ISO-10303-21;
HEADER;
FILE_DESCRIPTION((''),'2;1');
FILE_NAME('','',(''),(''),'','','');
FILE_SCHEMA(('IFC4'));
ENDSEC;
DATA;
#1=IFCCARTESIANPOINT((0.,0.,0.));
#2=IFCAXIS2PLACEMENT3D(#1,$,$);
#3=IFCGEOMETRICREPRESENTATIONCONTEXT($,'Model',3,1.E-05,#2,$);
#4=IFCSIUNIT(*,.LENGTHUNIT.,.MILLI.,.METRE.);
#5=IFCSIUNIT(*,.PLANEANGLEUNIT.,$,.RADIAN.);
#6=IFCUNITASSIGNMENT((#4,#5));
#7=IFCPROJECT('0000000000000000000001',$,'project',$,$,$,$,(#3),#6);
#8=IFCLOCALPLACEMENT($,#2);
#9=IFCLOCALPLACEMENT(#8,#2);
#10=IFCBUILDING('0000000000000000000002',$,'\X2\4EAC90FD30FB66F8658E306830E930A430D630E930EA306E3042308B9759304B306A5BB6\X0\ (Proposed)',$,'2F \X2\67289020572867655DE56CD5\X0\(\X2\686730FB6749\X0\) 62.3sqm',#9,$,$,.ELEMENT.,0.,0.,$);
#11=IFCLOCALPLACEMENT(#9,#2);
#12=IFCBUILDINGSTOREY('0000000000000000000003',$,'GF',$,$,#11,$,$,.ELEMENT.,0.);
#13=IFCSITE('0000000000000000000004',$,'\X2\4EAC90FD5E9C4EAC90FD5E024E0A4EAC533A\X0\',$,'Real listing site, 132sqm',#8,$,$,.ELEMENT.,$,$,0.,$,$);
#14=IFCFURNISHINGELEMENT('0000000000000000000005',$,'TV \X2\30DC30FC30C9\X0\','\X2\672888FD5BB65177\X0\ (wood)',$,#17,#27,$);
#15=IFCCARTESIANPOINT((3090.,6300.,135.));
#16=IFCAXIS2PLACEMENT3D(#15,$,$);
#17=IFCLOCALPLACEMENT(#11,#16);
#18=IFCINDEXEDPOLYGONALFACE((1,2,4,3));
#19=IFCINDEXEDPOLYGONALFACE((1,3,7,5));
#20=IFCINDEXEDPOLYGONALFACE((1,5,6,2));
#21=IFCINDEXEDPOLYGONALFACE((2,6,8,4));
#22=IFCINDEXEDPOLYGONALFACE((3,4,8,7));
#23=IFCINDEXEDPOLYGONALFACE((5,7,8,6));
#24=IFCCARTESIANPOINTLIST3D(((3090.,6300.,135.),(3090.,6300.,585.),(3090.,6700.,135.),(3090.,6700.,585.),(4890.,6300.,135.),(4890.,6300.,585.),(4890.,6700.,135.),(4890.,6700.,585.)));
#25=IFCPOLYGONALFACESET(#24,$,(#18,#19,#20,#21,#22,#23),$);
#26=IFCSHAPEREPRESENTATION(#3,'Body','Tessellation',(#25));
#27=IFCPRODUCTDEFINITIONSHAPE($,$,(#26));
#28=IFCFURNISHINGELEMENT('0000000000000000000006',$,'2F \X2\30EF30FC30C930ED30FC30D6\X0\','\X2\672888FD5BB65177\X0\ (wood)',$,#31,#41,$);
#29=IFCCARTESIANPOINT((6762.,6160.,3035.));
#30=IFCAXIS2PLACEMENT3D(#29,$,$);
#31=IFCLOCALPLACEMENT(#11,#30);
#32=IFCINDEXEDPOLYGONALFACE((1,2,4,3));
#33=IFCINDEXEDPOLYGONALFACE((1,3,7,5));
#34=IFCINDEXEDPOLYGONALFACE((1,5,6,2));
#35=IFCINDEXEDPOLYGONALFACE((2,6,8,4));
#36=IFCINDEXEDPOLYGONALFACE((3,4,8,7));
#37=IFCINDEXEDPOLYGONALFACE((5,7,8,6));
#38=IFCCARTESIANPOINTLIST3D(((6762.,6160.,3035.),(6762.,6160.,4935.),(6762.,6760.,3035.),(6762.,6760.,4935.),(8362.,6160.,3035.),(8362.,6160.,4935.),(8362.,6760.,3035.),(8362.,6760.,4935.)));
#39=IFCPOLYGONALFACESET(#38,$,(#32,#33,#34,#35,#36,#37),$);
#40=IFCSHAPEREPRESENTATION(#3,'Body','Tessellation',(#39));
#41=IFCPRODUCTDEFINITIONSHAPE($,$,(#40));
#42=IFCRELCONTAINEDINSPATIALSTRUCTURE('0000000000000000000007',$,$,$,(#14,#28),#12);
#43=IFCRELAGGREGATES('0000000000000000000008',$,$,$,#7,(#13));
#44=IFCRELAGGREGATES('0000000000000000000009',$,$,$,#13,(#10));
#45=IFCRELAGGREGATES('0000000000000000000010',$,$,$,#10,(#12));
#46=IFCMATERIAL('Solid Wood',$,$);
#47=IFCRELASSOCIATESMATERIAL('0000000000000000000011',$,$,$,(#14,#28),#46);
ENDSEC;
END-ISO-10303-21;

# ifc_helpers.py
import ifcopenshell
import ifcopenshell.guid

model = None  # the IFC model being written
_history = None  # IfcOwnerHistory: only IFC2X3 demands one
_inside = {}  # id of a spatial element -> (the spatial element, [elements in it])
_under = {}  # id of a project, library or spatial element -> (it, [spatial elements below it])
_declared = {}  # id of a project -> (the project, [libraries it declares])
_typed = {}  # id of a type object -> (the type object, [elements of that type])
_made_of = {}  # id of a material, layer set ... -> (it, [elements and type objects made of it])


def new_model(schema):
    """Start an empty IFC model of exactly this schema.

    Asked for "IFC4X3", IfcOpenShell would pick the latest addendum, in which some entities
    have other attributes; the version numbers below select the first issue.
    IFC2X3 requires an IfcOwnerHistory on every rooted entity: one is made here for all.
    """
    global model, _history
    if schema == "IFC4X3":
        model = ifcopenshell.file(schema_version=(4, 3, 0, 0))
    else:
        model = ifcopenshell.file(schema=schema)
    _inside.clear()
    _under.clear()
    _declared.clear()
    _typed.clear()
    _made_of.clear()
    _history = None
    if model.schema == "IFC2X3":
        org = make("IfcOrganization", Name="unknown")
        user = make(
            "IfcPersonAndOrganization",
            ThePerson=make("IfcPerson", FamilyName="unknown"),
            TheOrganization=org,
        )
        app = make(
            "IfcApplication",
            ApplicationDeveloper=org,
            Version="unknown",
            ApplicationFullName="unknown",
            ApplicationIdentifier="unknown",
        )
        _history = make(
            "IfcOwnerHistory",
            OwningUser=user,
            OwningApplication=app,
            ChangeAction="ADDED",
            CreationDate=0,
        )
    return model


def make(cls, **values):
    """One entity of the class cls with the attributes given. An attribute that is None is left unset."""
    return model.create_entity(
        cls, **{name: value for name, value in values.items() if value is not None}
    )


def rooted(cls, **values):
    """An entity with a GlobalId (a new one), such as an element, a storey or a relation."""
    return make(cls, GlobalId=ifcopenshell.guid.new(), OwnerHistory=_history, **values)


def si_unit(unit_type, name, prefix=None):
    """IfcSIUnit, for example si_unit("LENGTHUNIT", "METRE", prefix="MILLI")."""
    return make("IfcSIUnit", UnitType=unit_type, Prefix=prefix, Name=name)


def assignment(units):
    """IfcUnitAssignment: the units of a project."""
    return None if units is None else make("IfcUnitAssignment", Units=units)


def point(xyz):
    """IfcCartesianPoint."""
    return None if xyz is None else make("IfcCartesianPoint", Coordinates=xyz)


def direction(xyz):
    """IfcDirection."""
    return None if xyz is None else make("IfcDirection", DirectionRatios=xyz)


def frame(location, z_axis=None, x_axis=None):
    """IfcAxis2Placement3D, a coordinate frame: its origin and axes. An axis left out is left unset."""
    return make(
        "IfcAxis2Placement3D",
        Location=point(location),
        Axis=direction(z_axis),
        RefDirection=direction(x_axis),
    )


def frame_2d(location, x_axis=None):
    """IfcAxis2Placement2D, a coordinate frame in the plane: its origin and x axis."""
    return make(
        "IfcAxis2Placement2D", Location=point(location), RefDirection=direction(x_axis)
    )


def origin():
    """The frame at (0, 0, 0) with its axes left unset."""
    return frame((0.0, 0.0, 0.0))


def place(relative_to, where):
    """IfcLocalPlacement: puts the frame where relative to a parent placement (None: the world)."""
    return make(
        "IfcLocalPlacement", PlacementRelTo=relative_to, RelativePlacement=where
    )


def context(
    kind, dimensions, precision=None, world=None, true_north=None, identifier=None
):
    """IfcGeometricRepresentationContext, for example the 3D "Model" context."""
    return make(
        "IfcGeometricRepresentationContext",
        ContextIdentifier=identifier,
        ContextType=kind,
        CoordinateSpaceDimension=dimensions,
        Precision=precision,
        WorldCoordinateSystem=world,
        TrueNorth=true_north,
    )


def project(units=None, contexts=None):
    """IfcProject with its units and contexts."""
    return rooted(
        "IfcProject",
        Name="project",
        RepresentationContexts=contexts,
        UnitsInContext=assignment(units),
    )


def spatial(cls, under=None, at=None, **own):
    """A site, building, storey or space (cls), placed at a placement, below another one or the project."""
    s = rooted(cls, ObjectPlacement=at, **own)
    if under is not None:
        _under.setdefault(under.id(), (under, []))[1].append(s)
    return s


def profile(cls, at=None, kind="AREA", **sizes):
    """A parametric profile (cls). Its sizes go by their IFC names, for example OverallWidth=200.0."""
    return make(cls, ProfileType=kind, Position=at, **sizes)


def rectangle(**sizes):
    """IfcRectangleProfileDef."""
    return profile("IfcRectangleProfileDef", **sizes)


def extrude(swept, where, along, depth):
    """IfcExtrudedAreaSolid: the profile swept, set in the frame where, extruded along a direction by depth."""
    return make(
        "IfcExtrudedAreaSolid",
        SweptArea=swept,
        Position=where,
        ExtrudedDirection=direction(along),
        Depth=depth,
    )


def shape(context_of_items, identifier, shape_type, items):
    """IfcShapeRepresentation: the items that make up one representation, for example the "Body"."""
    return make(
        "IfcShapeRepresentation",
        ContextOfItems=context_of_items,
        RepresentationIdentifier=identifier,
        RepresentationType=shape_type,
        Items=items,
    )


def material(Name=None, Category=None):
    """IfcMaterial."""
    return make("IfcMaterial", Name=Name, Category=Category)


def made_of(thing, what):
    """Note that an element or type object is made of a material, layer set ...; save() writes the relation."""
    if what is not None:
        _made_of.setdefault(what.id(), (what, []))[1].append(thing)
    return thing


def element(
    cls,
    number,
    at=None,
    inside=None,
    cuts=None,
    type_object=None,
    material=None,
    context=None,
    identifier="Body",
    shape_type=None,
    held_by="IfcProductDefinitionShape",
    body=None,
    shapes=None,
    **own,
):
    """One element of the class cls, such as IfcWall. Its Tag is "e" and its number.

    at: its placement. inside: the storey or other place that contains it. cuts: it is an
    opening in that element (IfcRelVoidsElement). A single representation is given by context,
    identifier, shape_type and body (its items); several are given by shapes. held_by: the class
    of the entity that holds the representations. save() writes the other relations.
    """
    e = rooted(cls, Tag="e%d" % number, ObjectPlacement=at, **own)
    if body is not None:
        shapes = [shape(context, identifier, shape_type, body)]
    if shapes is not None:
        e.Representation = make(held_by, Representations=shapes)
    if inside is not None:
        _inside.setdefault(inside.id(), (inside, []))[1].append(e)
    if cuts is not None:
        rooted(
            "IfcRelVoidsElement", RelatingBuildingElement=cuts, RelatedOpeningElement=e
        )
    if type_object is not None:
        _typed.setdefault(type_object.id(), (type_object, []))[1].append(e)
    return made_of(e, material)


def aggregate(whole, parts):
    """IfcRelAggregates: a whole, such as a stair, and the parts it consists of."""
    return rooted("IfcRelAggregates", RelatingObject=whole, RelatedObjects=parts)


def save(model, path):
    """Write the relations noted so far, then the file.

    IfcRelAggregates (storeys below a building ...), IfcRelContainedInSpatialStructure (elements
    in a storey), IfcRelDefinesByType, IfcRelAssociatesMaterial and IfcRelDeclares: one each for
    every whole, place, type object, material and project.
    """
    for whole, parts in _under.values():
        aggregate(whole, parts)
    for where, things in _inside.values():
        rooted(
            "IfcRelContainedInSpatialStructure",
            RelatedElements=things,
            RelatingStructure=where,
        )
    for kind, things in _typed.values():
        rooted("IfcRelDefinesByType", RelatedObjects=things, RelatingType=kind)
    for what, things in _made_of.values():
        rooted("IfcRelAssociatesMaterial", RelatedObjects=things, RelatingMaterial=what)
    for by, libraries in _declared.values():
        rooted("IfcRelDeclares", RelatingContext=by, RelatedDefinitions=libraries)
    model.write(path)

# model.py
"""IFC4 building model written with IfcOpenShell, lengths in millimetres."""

from ifc_helpers import new_model, si_unit, frame, frame_2d, origin, place, context, project, spatial, rectangle, extrude, material, element, save


model = new_model("IFC4")

# Units and contexts
model_context = context("Model", 3, precision=1e-05, world=origin())
ifc_project = project(units=[si_unit("LENGTHUNIT", "METRE", prefix="MILLI"), si_unit("PLANEANGLEUNIT", "RADIAN")], contexts=[model_context])

# Site, building, storey
site_placement = place(None, origin())
site = spatial("IfcSite", under=ifc_project, at=site_placement, Name="京都府京都市上京区", ObjectType="Real listing site, 132sqm", CompositionType="ELEMENT", RefElevation=0.0)
building_placement = place(site_placement, origin())
building = spatial("IfcBuilding", under=site, at=building_placement, Name="京都・書斎とライブラリのある静かな家 (Proposed)", ObjectType="2F 木造在来工法(桧・杉) 62.3sqm", CompositionType="ELEMENT", ElevationOfRefHeight=0.0, ElevationOfTerrain=0.0)
storey_placement = place(building_placement, origin())
storey = spatial("IfcBuildingStorey", under=building, at=storey_placement, Name="GF", CompositionType="ELEMENT", Elevation=0.0)

# Shared definitions
ifc_material_1 = material(Name="Solid Wood")

# Furnishing elements
furnishing_1_placement = place(storey_placement, frame((3090.0, 6300.0, 135.0)))
element("IfcFurnishingElement", 1, at=furnishing_1_placement, inside=storey, material=ifc_material_1, Name="TV ボード", Description="木製家具 (wood)", context=model_context, shape_type="SweptSolid", body=[
    extrude(rectangle(XDim=1800.0, YDim=400.0, at=frame_2d((900.0, 200.0))), frame((3090.0, 6300.0, 135.0)), (0.0, 0.0, 1.0), 450.0),
])
furnishing_2_placement = place(storey_placement, frame((6762.0, 6160.0, 3035.0)))
element("IfcFurnishingElement", 2, at=furnishing_2_placement, inside=storey, material=ifc_material_1, Name="2F ワードローブ", Description="木製家具 (wood)", context=model_context, shape_type="SweptSolid", body=[
    extrude(rectangle(XDim=1600.0, YDim=600.0, at=frame_2d((800.0, 300.0))), frame((6762.0, 6160.0, 3035.0)), (0.0, 0.0, 1.0), 1900.0),
])

save(model, "model.ifc")
